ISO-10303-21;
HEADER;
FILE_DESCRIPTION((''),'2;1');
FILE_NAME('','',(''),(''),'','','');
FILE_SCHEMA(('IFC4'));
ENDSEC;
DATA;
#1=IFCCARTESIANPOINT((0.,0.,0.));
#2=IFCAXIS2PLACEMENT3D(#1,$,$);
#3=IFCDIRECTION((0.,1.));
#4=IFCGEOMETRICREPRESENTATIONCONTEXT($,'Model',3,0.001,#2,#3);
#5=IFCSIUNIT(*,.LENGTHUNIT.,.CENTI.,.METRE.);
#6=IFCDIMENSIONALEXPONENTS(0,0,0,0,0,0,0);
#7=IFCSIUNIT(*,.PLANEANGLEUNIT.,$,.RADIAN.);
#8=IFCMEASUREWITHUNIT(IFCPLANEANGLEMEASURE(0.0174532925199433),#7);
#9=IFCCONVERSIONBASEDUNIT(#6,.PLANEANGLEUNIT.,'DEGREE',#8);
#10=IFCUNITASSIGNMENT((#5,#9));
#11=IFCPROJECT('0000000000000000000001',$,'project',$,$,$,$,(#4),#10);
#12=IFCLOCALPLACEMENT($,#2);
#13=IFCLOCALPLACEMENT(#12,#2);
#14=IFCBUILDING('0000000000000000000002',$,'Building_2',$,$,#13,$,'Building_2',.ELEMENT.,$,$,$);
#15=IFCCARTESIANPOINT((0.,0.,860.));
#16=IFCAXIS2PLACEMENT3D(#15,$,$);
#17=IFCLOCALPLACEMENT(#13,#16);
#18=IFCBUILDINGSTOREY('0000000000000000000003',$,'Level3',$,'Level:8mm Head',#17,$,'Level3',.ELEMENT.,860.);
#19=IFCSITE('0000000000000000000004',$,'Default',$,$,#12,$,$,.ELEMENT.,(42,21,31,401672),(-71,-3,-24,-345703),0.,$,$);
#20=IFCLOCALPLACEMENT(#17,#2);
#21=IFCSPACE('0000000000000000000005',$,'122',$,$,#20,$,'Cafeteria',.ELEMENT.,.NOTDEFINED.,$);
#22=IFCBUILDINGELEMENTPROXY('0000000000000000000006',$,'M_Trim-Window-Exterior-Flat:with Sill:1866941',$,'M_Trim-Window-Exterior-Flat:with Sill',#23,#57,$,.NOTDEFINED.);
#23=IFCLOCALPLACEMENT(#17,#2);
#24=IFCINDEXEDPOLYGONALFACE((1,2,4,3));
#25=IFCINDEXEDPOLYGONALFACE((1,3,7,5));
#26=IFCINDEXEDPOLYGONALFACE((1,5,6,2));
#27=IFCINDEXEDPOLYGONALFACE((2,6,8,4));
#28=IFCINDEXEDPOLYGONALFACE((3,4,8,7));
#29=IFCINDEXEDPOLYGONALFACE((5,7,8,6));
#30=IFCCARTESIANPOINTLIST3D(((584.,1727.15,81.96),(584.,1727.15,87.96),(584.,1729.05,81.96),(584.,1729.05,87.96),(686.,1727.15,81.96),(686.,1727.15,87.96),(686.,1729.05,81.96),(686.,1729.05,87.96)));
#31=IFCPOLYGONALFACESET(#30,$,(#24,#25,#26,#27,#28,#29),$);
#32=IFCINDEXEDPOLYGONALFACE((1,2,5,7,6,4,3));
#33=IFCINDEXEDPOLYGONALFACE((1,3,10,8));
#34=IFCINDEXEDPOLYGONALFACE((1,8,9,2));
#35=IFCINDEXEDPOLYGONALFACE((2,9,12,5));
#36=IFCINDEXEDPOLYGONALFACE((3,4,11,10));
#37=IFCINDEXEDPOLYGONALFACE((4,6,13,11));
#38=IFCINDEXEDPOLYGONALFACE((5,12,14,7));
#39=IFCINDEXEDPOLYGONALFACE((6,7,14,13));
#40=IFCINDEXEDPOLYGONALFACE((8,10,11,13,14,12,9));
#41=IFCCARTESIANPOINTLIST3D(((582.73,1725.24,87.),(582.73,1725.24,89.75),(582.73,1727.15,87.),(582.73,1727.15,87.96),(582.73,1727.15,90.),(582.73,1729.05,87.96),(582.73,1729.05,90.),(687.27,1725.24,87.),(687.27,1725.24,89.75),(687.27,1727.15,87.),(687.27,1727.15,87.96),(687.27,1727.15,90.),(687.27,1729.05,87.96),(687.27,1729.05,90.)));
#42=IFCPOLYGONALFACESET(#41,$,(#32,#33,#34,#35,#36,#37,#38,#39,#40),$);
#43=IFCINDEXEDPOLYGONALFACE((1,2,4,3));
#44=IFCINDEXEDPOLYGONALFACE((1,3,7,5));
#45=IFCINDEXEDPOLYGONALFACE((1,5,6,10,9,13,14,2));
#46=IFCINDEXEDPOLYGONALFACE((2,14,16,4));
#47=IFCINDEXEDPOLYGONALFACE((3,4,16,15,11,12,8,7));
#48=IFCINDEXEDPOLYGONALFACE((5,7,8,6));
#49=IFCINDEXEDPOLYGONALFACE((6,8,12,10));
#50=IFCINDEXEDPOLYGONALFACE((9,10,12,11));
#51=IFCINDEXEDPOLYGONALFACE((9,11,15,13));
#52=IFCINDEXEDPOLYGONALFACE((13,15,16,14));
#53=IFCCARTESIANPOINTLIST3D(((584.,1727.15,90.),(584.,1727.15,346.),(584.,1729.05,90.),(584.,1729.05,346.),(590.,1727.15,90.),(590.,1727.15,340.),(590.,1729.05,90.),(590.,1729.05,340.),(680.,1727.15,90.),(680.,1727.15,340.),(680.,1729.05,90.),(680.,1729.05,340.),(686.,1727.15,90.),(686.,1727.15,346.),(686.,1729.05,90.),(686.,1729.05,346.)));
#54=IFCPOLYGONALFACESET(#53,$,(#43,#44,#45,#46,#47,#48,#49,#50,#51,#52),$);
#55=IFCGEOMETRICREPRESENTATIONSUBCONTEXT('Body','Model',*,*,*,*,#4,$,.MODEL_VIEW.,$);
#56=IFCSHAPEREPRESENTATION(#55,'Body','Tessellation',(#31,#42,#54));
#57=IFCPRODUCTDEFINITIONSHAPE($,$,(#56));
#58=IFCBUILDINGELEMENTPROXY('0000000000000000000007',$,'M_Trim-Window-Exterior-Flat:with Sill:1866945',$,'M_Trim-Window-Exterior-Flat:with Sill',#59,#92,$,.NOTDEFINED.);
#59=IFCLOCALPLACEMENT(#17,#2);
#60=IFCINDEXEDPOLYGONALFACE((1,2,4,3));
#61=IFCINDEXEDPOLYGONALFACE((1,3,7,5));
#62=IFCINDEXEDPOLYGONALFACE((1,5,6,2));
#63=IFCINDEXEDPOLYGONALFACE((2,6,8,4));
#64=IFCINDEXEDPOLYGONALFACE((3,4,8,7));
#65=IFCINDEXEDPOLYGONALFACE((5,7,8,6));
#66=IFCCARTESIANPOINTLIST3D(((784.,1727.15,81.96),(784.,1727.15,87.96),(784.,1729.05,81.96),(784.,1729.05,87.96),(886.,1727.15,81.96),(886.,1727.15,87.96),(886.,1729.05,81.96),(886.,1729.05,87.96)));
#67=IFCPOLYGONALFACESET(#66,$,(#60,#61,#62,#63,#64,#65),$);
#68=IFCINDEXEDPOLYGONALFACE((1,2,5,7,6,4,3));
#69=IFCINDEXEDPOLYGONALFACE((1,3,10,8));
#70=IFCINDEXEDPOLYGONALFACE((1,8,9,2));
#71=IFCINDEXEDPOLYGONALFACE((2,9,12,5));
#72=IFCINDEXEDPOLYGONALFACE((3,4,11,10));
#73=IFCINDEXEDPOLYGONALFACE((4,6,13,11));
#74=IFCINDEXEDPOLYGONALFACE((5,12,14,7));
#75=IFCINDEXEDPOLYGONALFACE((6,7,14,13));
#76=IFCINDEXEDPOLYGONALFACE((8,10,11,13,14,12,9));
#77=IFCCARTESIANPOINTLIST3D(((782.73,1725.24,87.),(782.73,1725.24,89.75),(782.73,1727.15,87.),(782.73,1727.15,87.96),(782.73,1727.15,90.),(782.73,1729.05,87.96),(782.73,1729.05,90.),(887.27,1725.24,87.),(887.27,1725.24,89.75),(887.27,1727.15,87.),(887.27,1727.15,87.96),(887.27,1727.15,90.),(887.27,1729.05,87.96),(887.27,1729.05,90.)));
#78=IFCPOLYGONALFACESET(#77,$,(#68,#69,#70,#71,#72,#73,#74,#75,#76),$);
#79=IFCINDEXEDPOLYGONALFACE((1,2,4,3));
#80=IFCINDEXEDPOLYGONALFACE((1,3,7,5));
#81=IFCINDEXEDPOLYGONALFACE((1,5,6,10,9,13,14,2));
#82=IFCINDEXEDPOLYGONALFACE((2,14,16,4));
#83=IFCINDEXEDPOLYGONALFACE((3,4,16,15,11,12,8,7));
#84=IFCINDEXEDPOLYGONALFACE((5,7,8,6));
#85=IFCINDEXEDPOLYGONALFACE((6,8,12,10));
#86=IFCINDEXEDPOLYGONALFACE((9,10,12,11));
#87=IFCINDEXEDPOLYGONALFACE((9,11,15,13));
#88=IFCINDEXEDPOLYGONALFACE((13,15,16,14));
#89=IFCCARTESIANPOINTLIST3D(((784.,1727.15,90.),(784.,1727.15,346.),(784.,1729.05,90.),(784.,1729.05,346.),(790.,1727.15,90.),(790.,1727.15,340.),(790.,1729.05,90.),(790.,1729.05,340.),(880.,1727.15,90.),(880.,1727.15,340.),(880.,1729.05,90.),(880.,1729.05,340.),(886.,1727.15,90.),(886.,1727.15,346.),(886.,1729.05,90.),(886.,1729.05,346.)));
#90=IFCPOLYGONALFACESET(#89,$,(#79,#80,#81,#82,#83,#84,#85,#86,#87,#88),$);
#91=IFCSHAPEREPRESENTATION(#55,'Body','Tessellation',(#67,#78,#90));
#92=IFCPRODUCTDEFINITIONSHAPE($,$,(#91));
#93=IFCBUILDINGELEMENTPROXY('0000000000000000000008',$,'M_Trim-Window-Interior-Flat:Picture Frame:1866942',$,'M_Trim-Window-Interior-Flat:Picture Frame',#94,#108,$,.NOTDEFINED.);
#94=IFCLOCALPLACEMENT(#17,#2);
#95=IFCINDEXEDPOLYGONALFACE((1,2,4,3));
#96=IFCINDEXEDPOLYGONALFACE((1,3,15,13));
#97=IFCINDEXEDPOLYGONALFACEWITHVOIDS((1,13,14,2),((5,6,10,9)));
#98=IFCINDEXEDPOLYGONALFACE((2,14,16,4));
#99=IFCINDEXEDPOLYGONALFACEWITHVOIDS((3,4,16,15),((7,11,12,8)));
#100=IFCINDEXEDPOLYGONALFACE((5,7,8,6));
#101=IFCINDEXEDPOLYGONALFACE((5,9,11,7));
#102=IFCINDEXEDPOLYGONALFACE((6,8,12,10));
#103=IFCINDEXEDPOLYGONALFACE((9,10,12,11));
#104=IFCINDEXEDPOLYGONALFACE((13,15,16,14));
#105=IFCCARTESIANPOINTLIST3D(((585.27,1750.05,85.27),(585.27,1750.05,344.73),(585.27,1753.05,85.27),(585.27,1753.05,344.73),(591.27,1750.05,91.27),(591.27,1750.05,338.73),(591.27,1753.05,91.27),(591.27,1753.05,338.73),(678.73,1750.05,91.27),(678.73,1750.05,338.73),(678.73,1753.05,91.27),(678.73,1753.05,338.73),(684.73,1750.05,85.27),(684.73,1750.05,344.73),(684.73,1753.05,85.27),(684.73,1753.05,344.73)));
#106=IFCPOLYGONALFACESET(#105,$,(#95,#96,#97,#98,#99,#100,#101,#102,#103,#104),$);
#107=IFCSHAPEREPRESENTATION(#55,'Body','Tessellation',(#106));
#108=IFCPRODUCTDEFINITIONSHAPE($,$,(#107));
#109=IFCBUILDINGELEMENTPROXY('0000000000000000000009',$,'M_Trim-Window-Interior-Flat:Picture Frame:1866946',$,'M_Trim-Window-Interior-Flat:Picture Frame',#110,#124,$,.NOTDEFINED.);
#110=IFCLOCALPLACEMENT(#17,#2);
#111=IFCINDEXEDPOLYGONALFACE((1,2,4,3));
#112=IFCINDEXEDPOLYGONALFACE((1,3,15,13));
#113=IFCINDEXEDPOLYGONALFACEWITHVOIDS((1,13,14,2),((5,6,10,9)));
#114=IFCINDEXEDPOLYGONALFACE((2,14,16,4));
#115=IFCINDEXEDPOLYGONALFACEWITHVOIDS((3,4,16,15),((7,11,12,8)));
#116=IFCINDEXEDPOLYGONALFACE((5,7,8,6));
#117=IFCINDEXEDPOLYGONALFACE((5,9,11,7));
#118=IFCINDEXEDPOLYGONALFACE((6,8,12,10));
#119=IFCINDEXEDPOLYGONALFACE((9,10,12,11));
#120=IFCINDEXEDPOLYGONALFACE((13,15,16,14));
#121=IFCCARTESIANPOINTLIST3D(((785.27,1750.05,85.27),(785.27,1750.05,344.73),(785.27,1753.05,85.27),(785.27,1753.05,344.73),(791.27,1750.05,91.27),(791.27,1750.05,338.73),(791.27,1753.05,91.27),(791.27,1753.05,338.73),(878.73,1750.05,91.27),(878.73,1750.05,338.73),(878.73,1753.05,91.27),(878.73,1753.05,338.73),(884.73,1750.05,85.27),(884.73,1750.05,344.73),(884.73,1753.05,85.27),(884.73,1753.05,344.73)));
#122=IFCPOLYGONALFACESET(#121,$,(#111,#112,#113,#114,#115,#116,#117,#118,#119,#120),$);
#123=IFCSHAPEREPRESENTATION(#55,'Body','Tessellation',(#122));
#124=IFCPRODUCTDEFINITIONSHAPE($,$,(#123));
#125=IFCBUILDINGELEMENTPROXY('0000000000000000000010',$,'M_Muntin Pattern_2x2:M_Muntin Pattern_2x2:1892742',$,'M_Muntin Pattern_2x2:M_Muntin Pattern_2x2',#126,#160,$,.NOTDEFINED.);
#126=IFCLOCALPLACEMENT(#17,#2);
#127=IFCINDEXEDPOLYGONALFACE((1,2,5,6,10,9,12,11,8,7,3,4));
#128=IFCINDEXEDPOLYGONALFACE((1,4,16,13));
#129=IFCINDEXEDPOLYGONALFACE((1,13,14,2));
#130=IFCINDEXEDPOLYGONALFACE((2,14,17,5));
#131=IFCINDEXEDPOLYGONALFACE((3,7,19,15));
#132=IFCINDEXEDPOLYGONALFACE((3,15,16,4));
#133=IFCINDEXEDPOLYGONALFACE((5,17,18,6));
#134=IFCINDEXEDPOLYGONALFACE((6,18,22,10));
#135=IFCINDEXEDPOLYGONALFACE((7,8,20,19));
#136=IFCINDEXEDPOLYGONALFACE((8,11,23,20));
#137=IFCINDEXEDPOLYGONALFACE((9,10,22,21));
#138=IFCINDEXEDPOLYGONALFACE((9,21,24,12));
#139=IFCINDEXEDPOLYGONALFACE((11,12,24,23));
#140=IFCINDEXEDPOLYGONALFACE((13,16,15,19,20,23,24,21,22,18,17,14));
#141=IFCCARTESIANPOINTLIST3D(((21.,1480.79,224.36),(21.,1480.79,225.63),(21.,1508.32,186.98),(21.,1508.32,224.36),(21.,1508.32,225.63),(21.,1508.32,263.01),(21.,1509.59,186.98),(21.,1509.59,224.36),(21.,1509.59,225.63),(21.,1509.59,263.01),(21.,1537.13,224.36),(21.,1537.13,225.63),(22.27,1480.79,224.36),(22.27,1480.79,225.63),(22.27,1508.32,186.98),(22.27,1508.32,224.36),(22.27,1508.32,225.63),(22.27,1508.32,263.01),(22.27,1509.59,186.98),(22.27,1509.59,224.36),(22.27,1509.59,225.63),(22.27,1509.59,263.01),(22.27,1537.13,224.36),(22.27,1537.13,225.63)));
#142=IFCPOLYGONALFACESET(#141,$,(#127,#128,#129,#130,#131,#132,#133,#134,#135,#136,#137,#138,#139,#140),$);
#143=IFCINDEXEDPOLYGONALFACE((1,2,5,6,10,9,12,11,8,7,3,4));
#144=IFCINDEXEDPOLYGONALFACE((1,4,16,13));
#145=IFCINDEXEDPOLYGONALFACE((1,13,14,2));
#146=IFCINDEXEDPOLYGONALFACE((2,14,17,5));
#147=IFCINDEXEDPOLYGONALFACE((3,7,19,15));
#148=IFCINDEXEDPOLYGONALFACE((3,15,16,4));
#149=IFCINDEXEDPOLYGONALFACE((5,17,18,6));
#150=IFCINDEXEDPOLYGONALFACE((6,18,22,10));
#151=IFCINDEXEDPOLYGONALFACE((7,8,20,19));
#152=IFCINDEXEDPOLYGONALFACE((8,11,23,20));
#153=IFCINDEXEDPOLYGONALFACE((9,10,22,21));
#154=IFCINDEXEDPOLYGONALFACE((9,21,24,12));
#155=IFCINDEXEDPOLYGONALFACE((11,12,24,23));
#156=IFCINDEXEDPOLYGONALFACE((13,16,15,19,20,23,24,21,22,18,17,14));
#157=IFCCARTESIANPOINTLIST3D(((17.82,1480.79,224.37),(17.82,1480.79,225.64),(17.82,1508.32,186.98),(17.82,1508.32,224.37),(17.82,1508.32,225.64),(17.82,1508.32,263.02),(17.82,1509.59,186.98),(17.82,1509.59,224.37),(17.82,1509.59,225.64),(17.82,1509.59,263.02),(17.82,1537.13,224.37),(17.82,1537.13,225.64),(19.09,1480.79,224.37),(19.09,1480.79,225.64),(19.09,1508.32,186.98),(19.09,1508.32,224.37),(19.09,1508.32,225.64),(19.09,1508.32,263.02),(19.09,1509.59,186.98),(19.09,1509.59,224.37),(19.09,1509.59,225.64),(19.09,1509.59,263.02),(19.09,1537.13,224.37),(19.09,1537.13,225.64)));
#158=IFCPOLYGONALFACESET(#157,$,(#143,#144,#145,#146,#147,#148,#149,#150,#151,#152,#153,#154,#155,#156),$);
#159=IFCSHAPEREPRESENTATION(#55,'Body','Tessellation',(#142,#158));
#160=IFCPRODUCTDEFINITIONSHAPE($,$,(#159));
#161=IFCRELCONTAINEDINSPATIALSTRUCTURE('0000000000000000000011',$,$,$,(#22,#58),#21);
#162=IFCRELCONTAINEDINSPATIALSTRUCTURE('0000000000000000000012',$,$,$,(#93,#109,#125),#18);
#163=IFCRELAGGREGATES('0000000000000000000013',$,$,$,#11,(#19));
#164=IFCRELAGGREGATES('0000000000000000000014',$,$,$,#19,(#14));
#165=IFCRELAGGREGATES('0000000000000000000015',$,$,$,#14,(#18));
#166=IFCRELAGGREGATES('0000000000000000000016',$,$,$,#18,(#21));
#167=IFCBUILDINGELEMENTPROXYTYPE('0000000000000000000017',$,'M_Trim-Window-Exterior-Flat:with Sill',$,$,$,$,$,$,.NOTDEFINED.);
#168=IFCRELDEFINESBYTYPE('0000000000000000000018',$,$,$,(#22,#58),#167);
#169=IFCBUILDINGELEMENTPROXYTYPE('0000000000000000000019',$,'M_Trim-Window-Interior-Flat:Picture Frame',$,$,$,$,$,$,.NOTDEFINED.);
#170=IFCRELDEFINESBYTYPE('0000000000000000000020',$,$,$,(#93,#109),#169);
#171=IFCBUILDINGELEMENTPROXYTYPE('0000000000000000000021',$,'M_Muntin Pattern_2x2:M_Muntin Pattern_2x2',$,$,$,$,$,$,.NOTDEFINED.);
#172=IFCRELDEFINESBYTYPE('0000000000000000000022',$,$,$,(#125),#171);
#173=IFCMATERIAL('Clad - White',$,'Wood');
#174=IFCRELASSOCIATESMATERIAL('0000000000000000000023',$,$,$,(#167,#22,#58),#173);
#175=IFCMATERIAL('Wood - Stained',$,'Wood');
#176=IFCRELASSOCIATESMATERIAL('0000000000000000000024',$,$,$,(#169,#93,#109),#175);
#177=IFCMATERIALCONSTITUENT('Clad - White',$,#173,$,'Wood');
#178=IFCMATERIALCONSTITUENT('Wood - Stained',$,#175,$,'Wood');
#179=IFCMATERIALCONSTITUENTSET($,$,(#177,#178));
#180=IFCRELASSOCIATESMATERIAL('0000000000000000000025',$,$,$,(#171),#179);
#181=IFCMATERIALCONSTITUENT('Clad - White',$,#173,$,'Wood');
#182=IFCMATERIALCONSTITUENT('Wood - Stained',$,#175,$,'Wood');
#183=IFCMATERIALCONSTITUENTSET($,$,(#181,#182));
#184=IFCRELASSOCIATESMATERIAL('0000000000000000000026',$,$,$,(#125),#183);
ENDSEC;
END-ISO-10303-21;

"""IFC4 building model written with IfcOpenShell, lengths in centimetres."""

from ifc_helpers import new_model, entity, si_unit, converted_unit, direction, frame, origin, place, context, subcontext, project, spatial, indexed_curve, outline, extrude, source, transform, mapped, material, constituent, constituent_set, type_object, type_shapes, element, save


model = new_model("IFC4")

# Units and contexts
model_context = context("Model", 3, precision=0.001, world=origin(), true_north=direction((0.0, 1.0)))
body_context = subcontext(model_context, "Body", "Model", "MODEL_VIEW")
ifc_project = project(units=[si_unit("LENGTHUNIT", "METRE", prefix="CENTI"), converted_unit("PLANEANGLEUNIT", "DEGREE", entity("IfcPlaneAngleMeasure", 0.0174532925199433), si_unit("PLANEANGLEUNIT", "RADIAN"), dimensions=[0, 0, 0, 0, 0, 0, 0])], contexts=[model_context])

# Site, building, storey
site_placement = place(None, origin())
site = spatial("IfcSite", under=ifc_project, at=site_placement, Name="Default", CompositionType="ELEMENT", RefLatitude=(42, 21, 31, 401672), RefLongitude=(-71, -3, -24, -345703), RefElevation=0.0)
building_placement = place(site_placement, origin())
building = spatial("IfcBuilding", under=site, at=building_placement, Name="Building_2", LongName="Building_2", CompositionType="ELEMENT")
storey_placement = place(building_placement, frame((0.0, 0.0, 860.0)))
storey = spatial("IfcBuildingStorey", under=building, at=storey_placement, Name="Level3", ObjectType="Level:8mm Head", LongName="Level3", CompositionType="ELEMENT", Elevation=860.0)

# Shared definitions
ifc_material_1 = material(Name="Clad - White", Category="Wood")
ifc_material_2 = material(Name="Wood - Stained", Category="Wood")

# Shared definitions
space_1_placement = place(storey_placement, origin())
space_1 = spatial("IfcSpace", under=storey, at=space_1_placement, Name="122", LongName="Cafeteria", CompositionType="ELEMENT", PredefinedType="NOTDEFINED")

# Building element proxies
building_element_proxy_type_1 = type_object("IfcBuildingElementProxyType", Name="M_Trim-Window-Exterior-Flat:with Sill", PredefinedType="NOTDEFINED", material=ifc_material_1)
shared_shape_1 = source(origin(), body_context, "Body", "SweptSolid", [
    extrude(outline(indexed_curve([(-3.0, -51.0), (3.0, -51.0), (3.0, 51.0), (-3.0, 51.0), (-3.0, -51.0)], self_intersect=False)), frame((0.0, 255.04, 0.0), z_axis=(0.0, 0.0, 1.0), x_axis=(0.0, 1.0, 0.0)), (0.0, 0.0, 1.0), 1.91),
    extrude(outline(indexed_curve([(-1.52, -1.9), (1.23, -1.9), (1.48, 0.0), (1.48, 1.9), (-0.57, 1.9), (-0.57, 0.0), (-1.52, 0.0), (-1.52, -1.9)], self_intersect=False)), frame((-52.27, 251.48, 1.9), z_axis=(1.0, 0.0, 0.0), x_axis=(0.0, -1.0, 0.0)), (0.0, 0.0, 1.0), 104.54),
    extrude(outline(indexed_curve([(-51.0, -129.5), (51.0, -129.5), (51.0, 126.5), (45.0, 126.5), (45.0, -123.5), (-45.0, -123.5), (-45.0, 126.5), (-51.0, 126.5), (-51.0, -129.5)], self_intersect=False)), frame((0.0, 123.5, 0.0)), (0.0, 0.0, 1.0), 1.91),
])
type_shapes(building_element_proxy_type_1, [shared_shape_1])
for number, where, z_axis, x_axis, name in (
    (1, (635.0, 1729.05, 340.0), (0.0, -1.0, 0.0), (-1.0, 0.0, 0.0), "M_Trim-Window-Exterior-Flat:with Sill:1866941"),
    (2, (835.0, 1729.05, 340.0), (0.0, -1.0, 0.0), (-1.0, 0.0, 0.0), "M_Trim-Window-Exterior-Flat:with Sill:1866945"),
):
    element("IfcBuildingElementProxy", number, at=place(space_1_placement, frame(where, z_axis=z_axis, x_axis=x_axis)), inside=space_1, type_object=building_element_proxy_type_1, material=ifc_material_1, Name=name, ObjectType="M_Trim-Window-Exterior-Flat:with Sill", PredefinedType="NOTDEFINED", context=body_context, shape_type="MappedRepresentation", body=[
        mapped(shared_shape_1, transform((0.0, 0.0, 0.0), scale=1.0)),
    ])
building_element_proxy_type_2 = type_object("IfcBuildingElementProxyType", Name="M_Trim-Window-Interior-Flat:Picture Frame", PredefinedType="NOTDEFINED", material=ifc_material_2)
shared_shape_2 = source(origin(), body_context, "Body", "SweptSolid", [
    extrude(outline(indexed_curve([(-129.73, -49.73), (129.73, -49.73), (129.73, 49.73), (-129.73, 49.73), (-129.73, -49.73)], self_intersect=False), holes=[indexed_curve([(-123.73, -43.73), (-123.73, 43.73), (123.73, 43.73), (123.73, -43.73), (-123.73, -43.73)], self_intersect=False)]), frame((0.0, 125.0, 0.0), z_axis=(0.0, 0.0, 1.0), x_axis=(0.0, 1.0, 0.0)), (0.0, 0.0, 1.0), 3.0),
])
type_shapes(building_element_proxy_type_2, [shared_shape_2])
for number, where, z_axis, x_axis, name in (
    (3, (635.0, 1750.05, 340.0), (0.0, 1.0, 0.0), (1.0, 0.0, 0.0), "M_Trim-Window-Interior-Flat:Picture Frame:1866942"),
    (4, (835.0, 1750.05, 340.0), (0.0, 1.0, 0.0), (1.0, 0.0, 0.0), "M_Trim-Window-Interior-Flat:Picture Frame:1866946"),
):
    element("IfcBuildingElementProxy", number, at=place(storey_placement, frame(where, z_axis=z_axis, x_axis=x_axis)), inside=storey, type_object=building_element_proxy_type_2, material=ifc_material_2, Name=name, ObjectType="M_Trim-Window-Interior-Flat:Picture Frame", PredefinedType="NOTDEFINED", context=body_context, shape_type="MappedRepresentation", body=[
        mapped(shared_shape_2, transform((0.0, 0.0, 0.0), scale=1.0)),
    ])
ifc_constituent_1 = constituent(ifc_material_1, Name="Clad - White", Category="Wood")
ifc_constituent_2 = constituent(ifc_material_2, Name="Wood - Stained", Category="Wood")
ifc_constituent_set_1 = constituent_set(constituents=[ifc_constituent_1, ifc_constituent_2])
ifc_constituent_3 = constituent(ifc_material_1, Name="Clad - White", Category="Wood")
ifc_constituent_4 = constituent(ifc_material_2, Name="Wood - Stained", Category="Wood")
ifc_constituent_set_2 = constituent_set(constituents=[ifc_constituent_3, ifc_constituent_4])
building_element_proxy_type_3 = type_object("IfcBuildingElementProxyType", Name="M_Muntin Pattern_2x2:M_Muntin Pattern_2x2", PredefinedType="NOTDEFINED", material=ifc_constituent_set_2)
shared_shape_3 = source(origin(), body_context, "Body", "SweptSolid", [
    extrude(outline(indexed_curve([(0.64, -0.64), (38.01, -0.64), (38.01, 0.63), (0.64, 0.63), (0.64, 28.17), (-0.63, 28.17), (-0.63, 0.63), (-38.02, 0.63), (-38.02, -0.64), (-0.63, -0.64), (-0.63, -28.17), (0.64, -28.17), (0.64, -0.64)], self_intersect=False)), frame((0.0, -2.22, 38.01), z_axis=(0.0, 1.0, 0.0), x_axis=(0.0, 0.0, 1.0)), (0.0, 0.0, 1.0), 1.27),
    extrude(outline(indexed_curve([(0.64, -0.64), (38.02, -0.64), (38.02, 0.63), (0.64, 0.63), (0.64, 28.17), (-0.63, 28.17), (-0.63, 0.63), (-38.02, 0.63), (-38.02, -0.64), (-0.63, -0.64), (-0.63, -28.17), (0.64, -28.17), (0.64, -0.64)], self_intersect=False)), frame((0.0, 0.95, 38.02), z_axis=(0.0, 1.0, 0.0), x_axis=(0.0, 0.0, 1.0)), (0.0, 0.0, 1.0), 1.27),
])
type_shapes(building_element_proxy_type_3, [shared_shape_3])
proxy_1_placement = place(storey_placement, frame((20.05, 1508.96, 186.98), z_axis=(0.0, 0.0, 1.0), x_axis=(0.0, 1.0, 0.0)))
element("IfcBuildingElementProxy", 5, at=proxy_1_placement, inside=storey, type_object=building_element_proxy_type_3, material=ifc_constituent_set_1, Name="M_Muntin Pattern_2x2:M_Muntin Pattern_2x2:1892742", ObjectType="M_Muntin Pattern_2x2:M_Muntin Pattern_2x2", PredefinedType="NOTDEFINED", context=body_context, shape_type="MappedRepresentation", body=[
    mapped(shared_shape_3, transform((0.0, 0.0, 0.0), scale=1.0)),
])

save(model, "model.ifc")
